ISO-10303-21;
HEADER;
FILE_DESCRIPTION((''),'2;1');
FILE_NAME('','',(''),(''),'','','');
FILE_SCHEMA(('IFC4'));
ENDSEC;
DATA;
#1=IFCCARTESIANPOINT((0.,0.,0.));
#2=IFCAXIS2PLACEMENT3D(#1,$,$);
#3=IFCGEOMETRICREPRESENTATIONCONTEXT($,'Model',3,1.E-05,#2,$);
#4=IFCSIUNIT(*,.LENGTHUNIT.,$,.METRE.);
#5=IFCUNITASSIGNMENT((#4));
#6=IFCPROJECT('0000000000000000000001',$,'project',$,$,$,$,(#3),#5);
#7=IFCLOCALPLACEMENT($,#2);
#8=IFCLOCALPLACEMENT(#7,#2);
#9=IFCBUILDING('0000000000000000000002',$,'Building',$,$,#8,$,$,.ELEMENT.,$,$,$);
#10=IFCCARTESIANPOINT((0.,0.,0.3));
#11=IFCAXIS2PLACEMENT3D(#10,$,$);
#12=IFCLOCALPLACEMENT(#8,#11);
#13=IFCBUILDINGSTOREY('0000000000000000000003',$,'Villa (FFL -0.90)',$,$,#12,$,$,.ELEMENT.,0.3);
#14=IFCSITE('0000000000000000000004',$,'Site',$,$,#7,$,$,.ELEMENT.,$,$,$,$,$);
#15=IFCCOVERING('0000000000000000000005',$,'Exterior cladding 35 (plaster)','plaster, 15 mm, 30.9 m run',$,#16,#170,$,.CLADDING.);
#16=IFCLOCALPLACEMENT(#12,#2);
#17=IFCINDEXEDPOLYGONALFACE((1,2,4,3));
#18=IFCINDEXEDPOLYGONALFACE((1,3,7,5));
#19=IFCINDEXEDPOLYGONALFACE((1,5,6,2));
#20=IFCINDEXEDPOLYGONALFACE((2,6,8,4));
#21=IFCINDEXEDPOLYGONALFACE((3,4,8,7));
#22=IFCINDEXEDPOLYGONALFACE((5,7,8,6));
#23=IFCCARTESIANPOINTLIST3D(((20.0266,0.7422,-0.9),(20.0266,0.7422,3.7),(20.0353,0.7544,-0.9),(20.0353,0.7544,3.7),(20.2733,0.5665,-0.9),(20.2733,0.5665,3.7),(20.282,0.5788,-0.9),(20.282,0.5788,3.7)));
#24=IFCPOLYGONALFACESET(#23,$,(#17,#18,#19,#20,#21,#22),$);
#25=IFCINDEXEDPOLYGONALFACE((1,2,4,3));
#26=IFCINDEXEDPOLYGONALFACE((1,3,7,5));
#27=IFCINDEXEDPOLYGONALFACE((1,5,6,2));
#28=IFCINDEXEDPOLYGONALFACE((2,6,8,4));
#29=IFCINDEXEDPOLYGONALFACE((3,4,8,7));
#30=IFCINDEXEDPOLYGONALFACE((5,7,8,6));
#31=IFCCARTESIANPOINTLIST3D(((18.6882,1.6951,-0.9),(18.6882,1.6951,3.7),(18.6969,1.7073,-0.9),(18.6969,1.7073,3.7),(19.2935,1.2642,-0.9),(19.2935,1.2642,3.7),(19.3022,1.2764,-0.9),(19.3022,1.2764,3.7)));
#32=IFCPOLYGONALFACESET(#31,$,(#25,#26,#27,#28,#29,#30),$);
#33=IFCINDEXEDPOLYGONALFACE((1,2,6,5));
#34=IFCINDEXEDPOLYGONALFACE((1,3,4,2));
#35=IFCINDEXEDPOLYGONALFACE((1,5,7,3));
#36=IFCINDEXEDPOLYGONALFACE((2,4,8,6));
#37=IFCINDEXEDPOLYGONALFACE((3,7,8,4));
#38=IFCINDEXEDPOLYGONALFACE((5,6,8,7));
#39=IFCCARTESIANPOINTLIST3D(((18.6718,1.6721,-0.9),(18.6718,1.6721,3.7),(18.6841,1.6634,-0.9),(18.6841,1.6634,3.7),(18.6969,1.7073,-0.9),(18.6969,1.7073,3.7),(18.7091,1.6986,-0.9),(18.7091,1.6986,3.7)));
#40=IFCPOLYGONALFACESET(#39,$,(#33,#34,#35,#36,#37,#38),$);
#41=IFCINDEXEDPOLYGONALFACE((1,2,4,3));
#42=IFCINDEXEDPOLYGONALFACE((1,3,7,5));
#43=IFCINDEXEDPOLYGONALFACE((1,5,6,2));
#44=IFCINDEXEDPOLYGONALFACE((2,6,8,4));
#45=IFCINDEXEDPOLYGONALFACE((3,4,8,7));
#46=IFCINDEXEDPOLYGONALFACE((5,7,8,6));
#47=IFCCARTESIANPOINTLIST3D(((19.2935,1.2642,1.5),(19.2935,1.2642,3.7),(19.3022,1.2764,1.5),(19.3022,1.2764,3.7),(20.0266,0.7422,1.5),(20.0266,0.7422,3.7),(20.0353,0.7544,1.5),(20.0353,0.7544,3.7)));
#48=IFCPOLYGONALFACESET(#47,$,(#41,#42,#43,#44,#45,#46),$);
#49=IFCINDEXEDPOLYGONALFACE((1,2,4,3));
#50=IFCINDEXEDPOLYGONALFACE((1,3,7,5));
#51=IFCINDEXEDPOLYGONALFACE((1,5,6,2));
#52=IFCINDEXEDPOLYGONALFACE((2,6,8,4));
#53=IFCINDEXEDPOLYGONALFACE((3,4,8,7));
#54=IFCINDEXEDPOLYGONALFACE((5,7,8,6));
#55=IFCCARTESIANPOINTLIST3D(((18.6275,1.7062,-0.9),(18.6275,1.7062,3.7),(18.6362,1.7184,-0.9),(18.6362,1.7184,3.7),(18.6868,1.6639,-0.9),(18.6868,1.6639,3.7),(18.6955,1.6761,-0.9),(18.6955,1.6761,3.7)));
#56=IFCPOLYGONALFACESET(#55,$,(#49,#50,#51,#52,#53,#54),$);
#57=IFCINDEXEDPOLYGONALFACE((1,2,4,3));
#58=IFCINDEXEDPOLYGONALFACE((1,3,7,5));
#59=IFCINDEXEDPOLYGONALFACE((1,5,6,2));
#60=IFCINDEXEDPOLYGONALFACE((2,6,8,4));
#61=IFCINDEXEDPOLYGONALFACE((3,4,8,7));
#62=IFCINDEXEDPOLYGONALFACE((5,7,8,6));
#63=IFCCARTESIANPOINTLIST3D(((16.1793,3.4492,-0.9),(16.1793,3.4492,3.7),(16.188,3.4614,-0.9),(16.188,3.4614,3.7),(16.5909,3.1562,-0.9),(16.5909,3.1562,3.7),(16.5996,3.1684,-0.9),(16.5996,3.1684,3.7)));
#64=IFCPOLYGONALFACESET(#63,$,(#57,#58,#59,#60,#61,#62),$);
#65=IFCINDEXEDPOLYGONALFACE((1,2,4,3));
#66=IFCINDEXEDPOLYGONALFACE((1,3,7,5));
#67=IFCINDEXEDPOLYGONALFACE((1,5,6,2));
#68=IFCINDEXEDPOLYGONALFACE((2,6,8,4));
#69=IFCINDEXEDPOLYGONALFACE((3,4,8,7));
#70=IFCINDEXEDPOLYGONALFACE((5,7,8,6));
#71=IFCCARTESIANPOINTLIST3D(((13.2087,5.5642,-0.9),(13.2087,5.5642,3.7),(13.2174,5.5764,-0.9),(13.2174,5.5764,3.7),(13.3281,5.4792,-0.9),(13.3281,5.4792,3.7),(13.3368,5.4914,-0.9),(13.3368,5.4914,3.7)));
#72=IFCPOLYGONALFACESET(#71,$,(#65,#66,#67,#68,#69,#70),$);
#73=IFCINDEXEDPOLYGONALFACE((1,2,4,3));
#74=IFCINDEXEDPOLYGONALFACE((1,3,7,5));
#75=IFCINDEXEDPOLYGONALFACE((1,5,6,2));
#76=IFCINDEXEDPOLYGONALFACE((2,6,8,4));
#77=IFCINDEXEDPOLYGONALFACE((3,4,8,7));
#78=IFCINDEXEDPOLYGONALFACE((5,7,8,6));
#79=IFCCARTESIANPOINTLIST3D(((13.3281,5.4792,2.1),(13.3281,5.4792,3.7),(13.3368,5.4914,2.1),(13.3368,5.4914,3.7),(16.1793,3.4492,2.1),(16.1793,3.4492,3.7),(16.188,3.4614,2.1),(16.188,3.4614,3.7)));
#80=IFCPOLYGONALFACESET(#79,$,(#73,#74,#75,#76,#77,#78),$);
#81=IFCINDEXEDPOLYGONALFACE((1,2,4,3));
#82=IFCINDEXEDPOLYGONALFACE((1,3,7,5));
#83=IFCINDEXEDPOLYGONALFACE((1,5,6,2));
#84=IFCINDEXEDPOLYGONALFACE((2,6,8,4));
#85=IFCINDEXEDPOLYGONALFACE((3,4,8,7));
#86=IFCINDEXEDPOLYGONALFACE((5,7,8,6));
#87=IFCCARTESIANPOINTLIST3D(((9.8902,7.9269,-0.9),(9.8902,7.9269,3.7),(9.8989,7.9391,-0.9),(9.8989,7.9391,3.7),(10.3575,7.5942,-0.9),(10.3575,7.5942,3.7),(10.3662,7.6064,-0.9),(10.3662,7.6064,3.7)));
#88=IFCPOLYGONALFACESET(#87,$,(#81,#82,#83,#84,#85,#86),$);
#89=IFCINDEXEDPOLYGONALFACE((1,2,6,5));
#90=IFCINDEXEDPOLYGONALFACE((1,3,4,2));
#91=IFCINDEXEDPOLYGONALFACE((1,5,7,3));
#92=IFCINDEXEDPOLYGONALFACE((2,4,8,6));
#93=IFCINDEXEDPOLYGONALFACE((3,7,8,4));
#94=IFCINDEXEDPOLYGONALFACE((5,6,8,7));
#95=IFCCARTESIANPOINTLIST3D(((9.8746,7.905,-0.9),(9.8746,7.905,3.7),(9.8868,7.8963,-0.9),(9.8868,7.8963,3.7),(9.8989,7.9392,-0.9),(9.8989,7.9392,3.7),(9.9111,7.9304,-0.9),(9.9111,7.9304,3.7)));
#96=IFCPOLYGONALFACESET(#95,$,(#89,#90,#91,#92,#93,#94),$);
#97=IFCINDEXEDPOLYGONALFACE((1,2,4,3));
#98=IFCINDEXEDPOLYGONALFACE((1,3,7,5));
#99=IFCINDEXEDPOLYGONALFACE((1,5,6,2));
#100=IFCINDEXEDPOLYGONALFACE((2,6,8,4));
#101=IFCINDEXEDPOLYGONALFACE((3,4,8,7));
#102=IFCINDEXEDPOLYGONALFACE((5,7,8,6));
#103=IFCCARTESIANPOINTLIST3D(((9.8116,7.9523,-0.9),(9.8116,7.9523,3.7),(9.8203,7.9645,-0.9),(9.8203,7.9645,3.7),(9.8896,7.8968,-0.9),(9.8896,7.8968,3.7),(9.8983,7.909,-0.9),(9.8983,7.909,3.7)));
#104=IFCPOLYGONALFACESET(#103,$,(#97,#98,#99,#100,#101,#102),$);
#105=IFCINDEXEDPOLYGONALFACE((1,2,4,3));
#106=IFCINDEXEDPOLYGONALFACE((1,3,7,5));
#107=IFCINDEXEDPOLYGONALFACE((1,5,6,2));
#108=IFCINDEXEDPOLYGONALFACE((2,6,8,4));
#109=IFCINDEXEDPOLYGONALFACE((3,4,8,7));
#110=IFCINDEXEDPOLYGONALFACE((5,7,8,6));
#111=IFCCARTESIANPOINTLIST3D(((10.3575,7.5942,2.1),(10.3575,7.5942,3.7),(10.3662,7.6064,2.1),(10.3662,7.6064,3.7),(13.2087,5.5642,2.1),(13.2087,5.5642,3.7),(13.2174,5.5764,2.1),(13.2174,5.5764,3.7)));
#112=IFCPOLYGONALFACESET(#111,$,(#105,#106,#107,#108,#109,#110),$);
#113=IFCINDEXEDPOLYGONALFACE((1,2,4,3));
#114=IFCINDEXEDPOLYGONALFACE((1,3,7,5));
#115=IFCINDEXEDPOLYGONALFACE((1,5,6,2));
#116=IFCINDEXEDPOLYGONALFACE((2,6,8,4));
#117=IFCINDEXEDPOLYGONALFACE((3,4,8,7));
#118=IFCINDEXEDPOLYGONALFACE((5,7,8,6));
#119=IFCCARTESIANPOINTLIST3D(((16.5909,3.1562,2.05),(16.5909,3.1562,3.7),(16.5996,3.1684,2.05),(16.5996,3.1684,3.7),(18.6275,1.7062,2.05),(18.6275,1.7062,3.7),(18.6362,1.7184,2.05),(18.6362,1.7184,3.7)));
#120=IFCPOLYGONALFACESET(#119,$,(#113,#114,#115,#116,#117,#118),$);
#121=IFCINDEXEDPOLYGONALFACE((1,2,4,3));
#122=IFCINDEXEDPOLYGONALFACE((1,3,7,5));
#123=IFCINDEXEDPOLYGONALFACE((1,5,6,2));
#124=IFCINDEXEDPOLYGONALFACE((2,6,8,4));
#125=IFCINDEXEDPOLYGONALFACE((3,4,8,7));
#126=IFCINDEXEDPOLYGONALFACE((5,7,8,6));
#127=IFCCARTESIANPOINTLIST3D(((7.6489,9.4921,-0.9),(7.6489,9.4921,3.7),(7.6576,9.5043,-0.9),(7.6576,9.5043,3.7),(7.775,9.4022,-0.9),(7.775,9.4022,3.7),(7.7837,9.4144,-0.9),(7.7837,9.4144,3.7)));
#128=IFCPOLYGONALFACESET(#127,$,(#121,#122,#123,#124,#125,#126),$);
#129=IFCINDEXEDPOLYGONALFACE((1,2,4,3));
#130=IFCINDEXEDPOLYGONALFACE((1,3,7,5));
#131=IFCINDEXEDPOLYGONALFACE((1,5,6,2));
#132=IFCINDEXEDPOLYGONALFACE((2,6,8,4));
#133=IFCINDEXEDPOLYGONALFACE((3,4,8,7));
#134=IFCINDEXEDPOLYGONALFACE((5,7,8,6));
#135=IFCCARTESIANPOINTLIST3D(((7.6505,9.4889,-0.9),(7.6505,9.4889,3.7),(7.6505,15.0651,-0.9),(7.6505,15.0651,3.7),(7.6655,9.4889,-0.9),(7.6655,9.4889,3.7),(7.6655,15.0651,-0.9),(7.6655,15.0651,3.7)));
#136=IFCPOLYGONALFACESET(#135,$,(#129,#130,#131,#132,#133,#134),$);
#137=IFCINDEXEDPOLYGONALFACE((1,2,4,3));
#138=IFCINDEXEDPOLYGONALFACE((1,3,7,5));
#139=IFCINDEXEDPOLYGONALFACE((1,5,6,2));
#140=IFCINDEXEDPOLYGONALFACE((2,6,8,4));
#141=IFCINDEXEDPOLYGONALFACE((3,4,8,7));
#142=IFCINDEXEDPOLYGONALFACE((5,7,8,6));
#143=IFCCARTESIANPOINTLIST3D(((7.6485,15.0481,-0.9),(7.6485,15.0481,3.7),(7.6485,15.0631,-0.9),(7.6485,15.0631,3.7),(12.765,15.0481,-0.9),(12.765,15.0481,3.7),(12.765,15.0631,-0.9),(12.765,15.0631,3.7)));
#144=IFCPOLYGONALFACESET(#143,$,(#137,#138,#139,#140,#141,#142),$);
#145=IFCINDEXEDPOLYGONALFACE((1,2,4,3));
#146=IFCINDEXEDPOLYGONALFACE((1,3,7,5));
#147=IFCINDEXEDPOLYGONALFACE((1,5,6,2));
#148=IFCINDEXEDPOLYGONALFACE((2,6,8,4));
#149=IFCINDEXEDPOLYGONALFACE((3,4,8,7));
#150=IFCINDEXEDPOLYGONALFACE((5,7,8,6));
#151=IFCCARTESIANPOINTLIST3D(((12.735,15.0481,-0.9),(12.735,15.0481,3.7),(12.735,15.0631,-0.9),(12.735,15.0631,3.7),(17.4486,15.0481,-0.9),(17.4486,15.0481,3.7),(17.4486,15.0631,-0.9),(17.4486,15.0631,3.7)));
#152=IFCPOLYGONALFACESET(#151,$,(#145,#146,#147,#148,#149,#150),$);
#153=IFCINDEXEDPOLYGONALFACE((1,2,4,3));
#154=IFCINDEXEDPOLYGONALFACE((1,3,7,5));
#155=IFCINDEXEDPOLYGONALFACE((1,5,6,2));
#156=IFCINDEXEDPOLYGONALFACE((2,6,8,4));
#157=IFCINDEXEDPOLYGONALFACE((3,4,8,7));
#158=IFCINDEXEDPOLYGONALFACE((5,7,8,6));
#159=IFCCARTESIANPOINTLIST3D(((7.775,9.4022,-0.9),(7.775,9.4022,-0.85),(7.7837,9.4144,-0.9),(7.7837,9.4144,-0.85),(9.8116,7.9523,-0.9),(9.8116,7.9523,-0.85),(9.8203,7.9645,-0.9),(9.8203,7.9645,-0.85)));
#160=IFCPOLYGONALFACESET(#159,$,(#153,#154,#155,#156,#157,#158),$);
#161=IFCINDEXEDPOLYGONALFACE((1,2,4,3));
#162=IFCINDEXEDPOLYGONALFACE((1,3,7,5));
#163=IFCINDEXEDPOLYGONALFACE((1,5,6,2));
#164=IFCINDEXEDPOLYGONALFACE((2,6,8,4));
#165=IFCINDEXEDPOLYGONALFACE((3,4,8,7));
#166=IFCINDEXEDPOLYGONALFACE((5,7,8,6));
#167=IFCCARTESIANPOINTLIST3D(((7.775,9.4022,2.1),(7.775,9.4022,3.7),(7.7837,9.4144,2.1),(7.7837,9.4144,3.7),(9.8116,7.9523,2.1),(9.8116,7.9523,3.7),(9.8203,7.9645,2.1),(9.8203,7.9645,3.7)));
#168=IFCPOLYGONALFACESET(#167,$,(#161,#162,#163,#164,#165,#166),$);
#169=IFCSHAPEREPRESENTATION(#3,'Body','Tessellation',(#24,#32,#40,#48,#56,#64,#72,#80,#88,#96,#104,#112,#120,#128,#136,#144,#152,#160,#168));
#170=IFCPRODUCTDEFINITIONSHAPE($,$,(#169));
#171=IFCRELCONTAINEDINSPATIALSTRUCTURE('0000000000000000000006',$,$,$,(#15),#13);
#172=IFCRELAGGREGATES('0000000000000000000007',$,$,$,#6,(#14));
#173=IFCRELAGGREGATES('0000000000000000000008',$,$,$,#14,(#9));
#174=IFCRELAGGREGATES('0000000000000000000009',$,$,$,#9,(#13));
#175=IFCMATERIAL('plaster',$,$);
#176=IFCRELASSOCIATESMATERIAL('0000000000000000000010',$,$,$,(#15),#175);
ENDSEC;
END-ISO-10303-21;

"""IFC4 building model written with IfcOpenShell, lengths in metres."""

from ifc_helpers import new_model, si_unit, frame, origin, origin_with_axes, place, context, project, spatial, polyline, outline, extrude, material, element, save


model = new_model("IFC4")

# Units and contexts
model_context = context("Model", 3, precision=1e-05, world=origin())
ifc_project = project(units=[si_unit("LENGTHUNIT", "METRE")], contexts=[model_context])

# Site, building, storey
site_placement = place(None, origin())
site = spatial("IfcSite", under=ifc_project, at=site_placement, Name="Site", CompositionType="ELEMENT")
building_placement = place(site_placement, origin())
building = spatial("IfcBuilding", under=site, at=building_placement, Name="Building", CompositionType="ELEMENT")
storey_placement = place(building_placement, frame((0.0, 0.0, 0.3)))
storey = spatial("IfcBuildingStorey", under=building, at=storey_placement, Name="Villa (FFL -0.90)", CompositionType="ELEMENT", Elevation=0.3)

# Covering
ifc_material = material(Name="plaster")
covering_1_placement = place(storey_placement, origin_with_axes())
element("IfcCovering", 1, at=covering_1_placement, inside=storey, material=ifc_material, Name="Exterior cladding 35 (plaster)", Description="plaster, 15 mm, 30.9 m run", PredefinedType="CLADDING", context=model_context, shape_type="SweptSolid", body=[
    extrude(outline(polyline([(20.282, 0.5788), (20.0353, 0.7544), (20.0266, 0.7422), (20.2733, 0.5665), (20.282, 0.5788)])), frame((0.0, 0.0, -0.9)), (0.0, 0.0, 1.0), 4.6),
    extrude(outline(polyline([(19.3022, 1.2764), (18.6969, 1.7073), (18.6882, 1.6951), (19.2935, 1.2642), (19.3022, 1.2764)])), frame((0.0, 0.0, -0.9)), (0.0, 0.0, 1.0), 4.6),
    extrude(outline(polyline([(18.6969, 1.7073), (18.6718, 1.6721), (18.6841, 1.6634), (18.7091, 1.6986), (18.6969, 1.7073)])), frame((0.0, 0.0, -0.9)), (0.0, 0.0, 1.0), 4.6),
    extrude(outline(polyline([(20.0353, 0.7544), (19.3022, 1.2764), (19.2935, 1.2642), (20.0266, 0.7422), (20.0353, 0.7544)])), frame((0.0, 0.0, 1.5)), (0.0, 0.0, 1.0), 2.2),
    extrude(outline(polyline([(18.6955, 1.6761), (18.6362, 1.7184), (18.6275, 1.7062), (18.6868, 1.6639), (18.6955, 1.6761)])), frame((0.0, 0.0, -0.9)), (0.0, 0.0, 1.0), 4.6),
    extrude(outline(polyline([(16.5996, 3.1684), (16.188, 3.4614), (16.1793, 3.4492), (16.5909, 3.1562), (16.5996, 3.1684)])), frame((0.0, 0.0, -0.9)), (0.0, 0.0, 1.0), 4.6),
    extrude(outline(polyline([(13.3368, 5.4914), (13.2174, 5.5764), (13.2087, 5.5642), (13.3281, 5.4792), (13.3368, 5.4914)])), frame((0.0, 0.0, -0.9)), (0.0, 0.0, 1.0), 4.6),
    extrude(outline(polyline([(16.188, 3.4614), (13.3368, 5.4914), (13.3281, 5.4792), (16.1793, 3.4492), (16.188, 3.4614)])), frame((0.0, 0.0, 2.1)), (0.0, 0.0, 1.0), 1.6),
    extrude(outline(polyline([(10.3662, 7.6064), (9.8989, 7.9391), (9.8902, 7.9269), (10.3575, 7.5942), (10.3662, 7.6064)])), frame((0.0, 0.0, -0.9)), (0.0, 0.0, 1.0), 4.6),
    extrude(outline(polyline([(9.8989, 7.9391), (9.8746, 7.905), (9.8868, 7.8963), (9.9111, 7.9304), (9.8989, 7.9391)])), frame((0.0, 0.0, -0.9)), (0.0, 0.0, 1.0), 4.6),
    extrude(outline(polyline([(9.8983, 7.909), (9.8203, 7.9645), (9.8116, 7.9523), (9.8896, 7.8967), (9.8983, 7.909)])), frame((0.0, 0.0, -0.9)), (0.0, 0.0, 1.0), 4.6),
    extrude(outline(polyline([(13.2174, 5.5764), (10.3662, 7.6064), (10.3575, 7.5942), (13.2087, 5.5642), (13.2174, 5.5764)])), frame((0.0, 0.0, 2.1)), (0.0, 0.0, 1.0), 1.6),
    extrude(outline(polyline([(18.6362, 1.7184), (16.5996, 3.1684), (16.5909, 3.1562), (18.6275, 1.7062), (18.6362, 1.7184)])), frame((0.0, 0.0, 2.05)), (0.0, 0.0, 1.0), 1.65),
    extrude(outline(polyline([(7.7837, 9.4144), (7.6576, 9.5043), (7.6489, 9.4921), (7.775, 9.4022), (7.7837, 9.4144)])), frame((0.0, 0.0, -0.9)), (0.0, 0.0, 1.0), 4.6),
    extrude(outline(polyline([(7.6655, 9.4889), (7.6655, 15.0651), (7.6505, 15.0651), (7.6505, 9.4889), (7.6655, 9.4889)])), frame((0.0, 0.0, -0.9)), (0.0, 0.0, 1.0), 4.6),
    extrude(outline(polyline([(7.6485, 15.0481), (12.765, 15.0481), (12.765, 15.0631), (7.6485, 15.0631), (7.6485, 15.0481)])), frame((0.0, 0.0, -0.9)), (0.0, 0.0, 1.0), 4.6),
    extrude(outline(polyline([(12.735, 15.0481), (17.4486, 15.0481), (17.4486, 15.0631), (12.735, 15.0631), (12.735, 15.0481)])), frame((0.0, 0.0, -0.9)), (0.0, 0.0, 1.0), 4.6),
    extrude(outline(polyline([(9.8203, 7.9645), (7.7837, 9.4144), (7.775, 9.4022), (9.8116, 7.9523), (9.8203, 7.9645)])), frame((0.0, 0.0, -0.9)), (0.0, 0.0, 1.0), 0.05),
    extrude(outline(polyline([(9.8203, 7.9645), (7.7837, 9.4144), (7.775, 9.4022), (9.8116, 7.9523), (9.8203, 7.9645)])), frame((0.0, 0.0, 2.1)), (0.0, 0.0, 1.0), 1.6),
])

save(model, "model.ifc")
